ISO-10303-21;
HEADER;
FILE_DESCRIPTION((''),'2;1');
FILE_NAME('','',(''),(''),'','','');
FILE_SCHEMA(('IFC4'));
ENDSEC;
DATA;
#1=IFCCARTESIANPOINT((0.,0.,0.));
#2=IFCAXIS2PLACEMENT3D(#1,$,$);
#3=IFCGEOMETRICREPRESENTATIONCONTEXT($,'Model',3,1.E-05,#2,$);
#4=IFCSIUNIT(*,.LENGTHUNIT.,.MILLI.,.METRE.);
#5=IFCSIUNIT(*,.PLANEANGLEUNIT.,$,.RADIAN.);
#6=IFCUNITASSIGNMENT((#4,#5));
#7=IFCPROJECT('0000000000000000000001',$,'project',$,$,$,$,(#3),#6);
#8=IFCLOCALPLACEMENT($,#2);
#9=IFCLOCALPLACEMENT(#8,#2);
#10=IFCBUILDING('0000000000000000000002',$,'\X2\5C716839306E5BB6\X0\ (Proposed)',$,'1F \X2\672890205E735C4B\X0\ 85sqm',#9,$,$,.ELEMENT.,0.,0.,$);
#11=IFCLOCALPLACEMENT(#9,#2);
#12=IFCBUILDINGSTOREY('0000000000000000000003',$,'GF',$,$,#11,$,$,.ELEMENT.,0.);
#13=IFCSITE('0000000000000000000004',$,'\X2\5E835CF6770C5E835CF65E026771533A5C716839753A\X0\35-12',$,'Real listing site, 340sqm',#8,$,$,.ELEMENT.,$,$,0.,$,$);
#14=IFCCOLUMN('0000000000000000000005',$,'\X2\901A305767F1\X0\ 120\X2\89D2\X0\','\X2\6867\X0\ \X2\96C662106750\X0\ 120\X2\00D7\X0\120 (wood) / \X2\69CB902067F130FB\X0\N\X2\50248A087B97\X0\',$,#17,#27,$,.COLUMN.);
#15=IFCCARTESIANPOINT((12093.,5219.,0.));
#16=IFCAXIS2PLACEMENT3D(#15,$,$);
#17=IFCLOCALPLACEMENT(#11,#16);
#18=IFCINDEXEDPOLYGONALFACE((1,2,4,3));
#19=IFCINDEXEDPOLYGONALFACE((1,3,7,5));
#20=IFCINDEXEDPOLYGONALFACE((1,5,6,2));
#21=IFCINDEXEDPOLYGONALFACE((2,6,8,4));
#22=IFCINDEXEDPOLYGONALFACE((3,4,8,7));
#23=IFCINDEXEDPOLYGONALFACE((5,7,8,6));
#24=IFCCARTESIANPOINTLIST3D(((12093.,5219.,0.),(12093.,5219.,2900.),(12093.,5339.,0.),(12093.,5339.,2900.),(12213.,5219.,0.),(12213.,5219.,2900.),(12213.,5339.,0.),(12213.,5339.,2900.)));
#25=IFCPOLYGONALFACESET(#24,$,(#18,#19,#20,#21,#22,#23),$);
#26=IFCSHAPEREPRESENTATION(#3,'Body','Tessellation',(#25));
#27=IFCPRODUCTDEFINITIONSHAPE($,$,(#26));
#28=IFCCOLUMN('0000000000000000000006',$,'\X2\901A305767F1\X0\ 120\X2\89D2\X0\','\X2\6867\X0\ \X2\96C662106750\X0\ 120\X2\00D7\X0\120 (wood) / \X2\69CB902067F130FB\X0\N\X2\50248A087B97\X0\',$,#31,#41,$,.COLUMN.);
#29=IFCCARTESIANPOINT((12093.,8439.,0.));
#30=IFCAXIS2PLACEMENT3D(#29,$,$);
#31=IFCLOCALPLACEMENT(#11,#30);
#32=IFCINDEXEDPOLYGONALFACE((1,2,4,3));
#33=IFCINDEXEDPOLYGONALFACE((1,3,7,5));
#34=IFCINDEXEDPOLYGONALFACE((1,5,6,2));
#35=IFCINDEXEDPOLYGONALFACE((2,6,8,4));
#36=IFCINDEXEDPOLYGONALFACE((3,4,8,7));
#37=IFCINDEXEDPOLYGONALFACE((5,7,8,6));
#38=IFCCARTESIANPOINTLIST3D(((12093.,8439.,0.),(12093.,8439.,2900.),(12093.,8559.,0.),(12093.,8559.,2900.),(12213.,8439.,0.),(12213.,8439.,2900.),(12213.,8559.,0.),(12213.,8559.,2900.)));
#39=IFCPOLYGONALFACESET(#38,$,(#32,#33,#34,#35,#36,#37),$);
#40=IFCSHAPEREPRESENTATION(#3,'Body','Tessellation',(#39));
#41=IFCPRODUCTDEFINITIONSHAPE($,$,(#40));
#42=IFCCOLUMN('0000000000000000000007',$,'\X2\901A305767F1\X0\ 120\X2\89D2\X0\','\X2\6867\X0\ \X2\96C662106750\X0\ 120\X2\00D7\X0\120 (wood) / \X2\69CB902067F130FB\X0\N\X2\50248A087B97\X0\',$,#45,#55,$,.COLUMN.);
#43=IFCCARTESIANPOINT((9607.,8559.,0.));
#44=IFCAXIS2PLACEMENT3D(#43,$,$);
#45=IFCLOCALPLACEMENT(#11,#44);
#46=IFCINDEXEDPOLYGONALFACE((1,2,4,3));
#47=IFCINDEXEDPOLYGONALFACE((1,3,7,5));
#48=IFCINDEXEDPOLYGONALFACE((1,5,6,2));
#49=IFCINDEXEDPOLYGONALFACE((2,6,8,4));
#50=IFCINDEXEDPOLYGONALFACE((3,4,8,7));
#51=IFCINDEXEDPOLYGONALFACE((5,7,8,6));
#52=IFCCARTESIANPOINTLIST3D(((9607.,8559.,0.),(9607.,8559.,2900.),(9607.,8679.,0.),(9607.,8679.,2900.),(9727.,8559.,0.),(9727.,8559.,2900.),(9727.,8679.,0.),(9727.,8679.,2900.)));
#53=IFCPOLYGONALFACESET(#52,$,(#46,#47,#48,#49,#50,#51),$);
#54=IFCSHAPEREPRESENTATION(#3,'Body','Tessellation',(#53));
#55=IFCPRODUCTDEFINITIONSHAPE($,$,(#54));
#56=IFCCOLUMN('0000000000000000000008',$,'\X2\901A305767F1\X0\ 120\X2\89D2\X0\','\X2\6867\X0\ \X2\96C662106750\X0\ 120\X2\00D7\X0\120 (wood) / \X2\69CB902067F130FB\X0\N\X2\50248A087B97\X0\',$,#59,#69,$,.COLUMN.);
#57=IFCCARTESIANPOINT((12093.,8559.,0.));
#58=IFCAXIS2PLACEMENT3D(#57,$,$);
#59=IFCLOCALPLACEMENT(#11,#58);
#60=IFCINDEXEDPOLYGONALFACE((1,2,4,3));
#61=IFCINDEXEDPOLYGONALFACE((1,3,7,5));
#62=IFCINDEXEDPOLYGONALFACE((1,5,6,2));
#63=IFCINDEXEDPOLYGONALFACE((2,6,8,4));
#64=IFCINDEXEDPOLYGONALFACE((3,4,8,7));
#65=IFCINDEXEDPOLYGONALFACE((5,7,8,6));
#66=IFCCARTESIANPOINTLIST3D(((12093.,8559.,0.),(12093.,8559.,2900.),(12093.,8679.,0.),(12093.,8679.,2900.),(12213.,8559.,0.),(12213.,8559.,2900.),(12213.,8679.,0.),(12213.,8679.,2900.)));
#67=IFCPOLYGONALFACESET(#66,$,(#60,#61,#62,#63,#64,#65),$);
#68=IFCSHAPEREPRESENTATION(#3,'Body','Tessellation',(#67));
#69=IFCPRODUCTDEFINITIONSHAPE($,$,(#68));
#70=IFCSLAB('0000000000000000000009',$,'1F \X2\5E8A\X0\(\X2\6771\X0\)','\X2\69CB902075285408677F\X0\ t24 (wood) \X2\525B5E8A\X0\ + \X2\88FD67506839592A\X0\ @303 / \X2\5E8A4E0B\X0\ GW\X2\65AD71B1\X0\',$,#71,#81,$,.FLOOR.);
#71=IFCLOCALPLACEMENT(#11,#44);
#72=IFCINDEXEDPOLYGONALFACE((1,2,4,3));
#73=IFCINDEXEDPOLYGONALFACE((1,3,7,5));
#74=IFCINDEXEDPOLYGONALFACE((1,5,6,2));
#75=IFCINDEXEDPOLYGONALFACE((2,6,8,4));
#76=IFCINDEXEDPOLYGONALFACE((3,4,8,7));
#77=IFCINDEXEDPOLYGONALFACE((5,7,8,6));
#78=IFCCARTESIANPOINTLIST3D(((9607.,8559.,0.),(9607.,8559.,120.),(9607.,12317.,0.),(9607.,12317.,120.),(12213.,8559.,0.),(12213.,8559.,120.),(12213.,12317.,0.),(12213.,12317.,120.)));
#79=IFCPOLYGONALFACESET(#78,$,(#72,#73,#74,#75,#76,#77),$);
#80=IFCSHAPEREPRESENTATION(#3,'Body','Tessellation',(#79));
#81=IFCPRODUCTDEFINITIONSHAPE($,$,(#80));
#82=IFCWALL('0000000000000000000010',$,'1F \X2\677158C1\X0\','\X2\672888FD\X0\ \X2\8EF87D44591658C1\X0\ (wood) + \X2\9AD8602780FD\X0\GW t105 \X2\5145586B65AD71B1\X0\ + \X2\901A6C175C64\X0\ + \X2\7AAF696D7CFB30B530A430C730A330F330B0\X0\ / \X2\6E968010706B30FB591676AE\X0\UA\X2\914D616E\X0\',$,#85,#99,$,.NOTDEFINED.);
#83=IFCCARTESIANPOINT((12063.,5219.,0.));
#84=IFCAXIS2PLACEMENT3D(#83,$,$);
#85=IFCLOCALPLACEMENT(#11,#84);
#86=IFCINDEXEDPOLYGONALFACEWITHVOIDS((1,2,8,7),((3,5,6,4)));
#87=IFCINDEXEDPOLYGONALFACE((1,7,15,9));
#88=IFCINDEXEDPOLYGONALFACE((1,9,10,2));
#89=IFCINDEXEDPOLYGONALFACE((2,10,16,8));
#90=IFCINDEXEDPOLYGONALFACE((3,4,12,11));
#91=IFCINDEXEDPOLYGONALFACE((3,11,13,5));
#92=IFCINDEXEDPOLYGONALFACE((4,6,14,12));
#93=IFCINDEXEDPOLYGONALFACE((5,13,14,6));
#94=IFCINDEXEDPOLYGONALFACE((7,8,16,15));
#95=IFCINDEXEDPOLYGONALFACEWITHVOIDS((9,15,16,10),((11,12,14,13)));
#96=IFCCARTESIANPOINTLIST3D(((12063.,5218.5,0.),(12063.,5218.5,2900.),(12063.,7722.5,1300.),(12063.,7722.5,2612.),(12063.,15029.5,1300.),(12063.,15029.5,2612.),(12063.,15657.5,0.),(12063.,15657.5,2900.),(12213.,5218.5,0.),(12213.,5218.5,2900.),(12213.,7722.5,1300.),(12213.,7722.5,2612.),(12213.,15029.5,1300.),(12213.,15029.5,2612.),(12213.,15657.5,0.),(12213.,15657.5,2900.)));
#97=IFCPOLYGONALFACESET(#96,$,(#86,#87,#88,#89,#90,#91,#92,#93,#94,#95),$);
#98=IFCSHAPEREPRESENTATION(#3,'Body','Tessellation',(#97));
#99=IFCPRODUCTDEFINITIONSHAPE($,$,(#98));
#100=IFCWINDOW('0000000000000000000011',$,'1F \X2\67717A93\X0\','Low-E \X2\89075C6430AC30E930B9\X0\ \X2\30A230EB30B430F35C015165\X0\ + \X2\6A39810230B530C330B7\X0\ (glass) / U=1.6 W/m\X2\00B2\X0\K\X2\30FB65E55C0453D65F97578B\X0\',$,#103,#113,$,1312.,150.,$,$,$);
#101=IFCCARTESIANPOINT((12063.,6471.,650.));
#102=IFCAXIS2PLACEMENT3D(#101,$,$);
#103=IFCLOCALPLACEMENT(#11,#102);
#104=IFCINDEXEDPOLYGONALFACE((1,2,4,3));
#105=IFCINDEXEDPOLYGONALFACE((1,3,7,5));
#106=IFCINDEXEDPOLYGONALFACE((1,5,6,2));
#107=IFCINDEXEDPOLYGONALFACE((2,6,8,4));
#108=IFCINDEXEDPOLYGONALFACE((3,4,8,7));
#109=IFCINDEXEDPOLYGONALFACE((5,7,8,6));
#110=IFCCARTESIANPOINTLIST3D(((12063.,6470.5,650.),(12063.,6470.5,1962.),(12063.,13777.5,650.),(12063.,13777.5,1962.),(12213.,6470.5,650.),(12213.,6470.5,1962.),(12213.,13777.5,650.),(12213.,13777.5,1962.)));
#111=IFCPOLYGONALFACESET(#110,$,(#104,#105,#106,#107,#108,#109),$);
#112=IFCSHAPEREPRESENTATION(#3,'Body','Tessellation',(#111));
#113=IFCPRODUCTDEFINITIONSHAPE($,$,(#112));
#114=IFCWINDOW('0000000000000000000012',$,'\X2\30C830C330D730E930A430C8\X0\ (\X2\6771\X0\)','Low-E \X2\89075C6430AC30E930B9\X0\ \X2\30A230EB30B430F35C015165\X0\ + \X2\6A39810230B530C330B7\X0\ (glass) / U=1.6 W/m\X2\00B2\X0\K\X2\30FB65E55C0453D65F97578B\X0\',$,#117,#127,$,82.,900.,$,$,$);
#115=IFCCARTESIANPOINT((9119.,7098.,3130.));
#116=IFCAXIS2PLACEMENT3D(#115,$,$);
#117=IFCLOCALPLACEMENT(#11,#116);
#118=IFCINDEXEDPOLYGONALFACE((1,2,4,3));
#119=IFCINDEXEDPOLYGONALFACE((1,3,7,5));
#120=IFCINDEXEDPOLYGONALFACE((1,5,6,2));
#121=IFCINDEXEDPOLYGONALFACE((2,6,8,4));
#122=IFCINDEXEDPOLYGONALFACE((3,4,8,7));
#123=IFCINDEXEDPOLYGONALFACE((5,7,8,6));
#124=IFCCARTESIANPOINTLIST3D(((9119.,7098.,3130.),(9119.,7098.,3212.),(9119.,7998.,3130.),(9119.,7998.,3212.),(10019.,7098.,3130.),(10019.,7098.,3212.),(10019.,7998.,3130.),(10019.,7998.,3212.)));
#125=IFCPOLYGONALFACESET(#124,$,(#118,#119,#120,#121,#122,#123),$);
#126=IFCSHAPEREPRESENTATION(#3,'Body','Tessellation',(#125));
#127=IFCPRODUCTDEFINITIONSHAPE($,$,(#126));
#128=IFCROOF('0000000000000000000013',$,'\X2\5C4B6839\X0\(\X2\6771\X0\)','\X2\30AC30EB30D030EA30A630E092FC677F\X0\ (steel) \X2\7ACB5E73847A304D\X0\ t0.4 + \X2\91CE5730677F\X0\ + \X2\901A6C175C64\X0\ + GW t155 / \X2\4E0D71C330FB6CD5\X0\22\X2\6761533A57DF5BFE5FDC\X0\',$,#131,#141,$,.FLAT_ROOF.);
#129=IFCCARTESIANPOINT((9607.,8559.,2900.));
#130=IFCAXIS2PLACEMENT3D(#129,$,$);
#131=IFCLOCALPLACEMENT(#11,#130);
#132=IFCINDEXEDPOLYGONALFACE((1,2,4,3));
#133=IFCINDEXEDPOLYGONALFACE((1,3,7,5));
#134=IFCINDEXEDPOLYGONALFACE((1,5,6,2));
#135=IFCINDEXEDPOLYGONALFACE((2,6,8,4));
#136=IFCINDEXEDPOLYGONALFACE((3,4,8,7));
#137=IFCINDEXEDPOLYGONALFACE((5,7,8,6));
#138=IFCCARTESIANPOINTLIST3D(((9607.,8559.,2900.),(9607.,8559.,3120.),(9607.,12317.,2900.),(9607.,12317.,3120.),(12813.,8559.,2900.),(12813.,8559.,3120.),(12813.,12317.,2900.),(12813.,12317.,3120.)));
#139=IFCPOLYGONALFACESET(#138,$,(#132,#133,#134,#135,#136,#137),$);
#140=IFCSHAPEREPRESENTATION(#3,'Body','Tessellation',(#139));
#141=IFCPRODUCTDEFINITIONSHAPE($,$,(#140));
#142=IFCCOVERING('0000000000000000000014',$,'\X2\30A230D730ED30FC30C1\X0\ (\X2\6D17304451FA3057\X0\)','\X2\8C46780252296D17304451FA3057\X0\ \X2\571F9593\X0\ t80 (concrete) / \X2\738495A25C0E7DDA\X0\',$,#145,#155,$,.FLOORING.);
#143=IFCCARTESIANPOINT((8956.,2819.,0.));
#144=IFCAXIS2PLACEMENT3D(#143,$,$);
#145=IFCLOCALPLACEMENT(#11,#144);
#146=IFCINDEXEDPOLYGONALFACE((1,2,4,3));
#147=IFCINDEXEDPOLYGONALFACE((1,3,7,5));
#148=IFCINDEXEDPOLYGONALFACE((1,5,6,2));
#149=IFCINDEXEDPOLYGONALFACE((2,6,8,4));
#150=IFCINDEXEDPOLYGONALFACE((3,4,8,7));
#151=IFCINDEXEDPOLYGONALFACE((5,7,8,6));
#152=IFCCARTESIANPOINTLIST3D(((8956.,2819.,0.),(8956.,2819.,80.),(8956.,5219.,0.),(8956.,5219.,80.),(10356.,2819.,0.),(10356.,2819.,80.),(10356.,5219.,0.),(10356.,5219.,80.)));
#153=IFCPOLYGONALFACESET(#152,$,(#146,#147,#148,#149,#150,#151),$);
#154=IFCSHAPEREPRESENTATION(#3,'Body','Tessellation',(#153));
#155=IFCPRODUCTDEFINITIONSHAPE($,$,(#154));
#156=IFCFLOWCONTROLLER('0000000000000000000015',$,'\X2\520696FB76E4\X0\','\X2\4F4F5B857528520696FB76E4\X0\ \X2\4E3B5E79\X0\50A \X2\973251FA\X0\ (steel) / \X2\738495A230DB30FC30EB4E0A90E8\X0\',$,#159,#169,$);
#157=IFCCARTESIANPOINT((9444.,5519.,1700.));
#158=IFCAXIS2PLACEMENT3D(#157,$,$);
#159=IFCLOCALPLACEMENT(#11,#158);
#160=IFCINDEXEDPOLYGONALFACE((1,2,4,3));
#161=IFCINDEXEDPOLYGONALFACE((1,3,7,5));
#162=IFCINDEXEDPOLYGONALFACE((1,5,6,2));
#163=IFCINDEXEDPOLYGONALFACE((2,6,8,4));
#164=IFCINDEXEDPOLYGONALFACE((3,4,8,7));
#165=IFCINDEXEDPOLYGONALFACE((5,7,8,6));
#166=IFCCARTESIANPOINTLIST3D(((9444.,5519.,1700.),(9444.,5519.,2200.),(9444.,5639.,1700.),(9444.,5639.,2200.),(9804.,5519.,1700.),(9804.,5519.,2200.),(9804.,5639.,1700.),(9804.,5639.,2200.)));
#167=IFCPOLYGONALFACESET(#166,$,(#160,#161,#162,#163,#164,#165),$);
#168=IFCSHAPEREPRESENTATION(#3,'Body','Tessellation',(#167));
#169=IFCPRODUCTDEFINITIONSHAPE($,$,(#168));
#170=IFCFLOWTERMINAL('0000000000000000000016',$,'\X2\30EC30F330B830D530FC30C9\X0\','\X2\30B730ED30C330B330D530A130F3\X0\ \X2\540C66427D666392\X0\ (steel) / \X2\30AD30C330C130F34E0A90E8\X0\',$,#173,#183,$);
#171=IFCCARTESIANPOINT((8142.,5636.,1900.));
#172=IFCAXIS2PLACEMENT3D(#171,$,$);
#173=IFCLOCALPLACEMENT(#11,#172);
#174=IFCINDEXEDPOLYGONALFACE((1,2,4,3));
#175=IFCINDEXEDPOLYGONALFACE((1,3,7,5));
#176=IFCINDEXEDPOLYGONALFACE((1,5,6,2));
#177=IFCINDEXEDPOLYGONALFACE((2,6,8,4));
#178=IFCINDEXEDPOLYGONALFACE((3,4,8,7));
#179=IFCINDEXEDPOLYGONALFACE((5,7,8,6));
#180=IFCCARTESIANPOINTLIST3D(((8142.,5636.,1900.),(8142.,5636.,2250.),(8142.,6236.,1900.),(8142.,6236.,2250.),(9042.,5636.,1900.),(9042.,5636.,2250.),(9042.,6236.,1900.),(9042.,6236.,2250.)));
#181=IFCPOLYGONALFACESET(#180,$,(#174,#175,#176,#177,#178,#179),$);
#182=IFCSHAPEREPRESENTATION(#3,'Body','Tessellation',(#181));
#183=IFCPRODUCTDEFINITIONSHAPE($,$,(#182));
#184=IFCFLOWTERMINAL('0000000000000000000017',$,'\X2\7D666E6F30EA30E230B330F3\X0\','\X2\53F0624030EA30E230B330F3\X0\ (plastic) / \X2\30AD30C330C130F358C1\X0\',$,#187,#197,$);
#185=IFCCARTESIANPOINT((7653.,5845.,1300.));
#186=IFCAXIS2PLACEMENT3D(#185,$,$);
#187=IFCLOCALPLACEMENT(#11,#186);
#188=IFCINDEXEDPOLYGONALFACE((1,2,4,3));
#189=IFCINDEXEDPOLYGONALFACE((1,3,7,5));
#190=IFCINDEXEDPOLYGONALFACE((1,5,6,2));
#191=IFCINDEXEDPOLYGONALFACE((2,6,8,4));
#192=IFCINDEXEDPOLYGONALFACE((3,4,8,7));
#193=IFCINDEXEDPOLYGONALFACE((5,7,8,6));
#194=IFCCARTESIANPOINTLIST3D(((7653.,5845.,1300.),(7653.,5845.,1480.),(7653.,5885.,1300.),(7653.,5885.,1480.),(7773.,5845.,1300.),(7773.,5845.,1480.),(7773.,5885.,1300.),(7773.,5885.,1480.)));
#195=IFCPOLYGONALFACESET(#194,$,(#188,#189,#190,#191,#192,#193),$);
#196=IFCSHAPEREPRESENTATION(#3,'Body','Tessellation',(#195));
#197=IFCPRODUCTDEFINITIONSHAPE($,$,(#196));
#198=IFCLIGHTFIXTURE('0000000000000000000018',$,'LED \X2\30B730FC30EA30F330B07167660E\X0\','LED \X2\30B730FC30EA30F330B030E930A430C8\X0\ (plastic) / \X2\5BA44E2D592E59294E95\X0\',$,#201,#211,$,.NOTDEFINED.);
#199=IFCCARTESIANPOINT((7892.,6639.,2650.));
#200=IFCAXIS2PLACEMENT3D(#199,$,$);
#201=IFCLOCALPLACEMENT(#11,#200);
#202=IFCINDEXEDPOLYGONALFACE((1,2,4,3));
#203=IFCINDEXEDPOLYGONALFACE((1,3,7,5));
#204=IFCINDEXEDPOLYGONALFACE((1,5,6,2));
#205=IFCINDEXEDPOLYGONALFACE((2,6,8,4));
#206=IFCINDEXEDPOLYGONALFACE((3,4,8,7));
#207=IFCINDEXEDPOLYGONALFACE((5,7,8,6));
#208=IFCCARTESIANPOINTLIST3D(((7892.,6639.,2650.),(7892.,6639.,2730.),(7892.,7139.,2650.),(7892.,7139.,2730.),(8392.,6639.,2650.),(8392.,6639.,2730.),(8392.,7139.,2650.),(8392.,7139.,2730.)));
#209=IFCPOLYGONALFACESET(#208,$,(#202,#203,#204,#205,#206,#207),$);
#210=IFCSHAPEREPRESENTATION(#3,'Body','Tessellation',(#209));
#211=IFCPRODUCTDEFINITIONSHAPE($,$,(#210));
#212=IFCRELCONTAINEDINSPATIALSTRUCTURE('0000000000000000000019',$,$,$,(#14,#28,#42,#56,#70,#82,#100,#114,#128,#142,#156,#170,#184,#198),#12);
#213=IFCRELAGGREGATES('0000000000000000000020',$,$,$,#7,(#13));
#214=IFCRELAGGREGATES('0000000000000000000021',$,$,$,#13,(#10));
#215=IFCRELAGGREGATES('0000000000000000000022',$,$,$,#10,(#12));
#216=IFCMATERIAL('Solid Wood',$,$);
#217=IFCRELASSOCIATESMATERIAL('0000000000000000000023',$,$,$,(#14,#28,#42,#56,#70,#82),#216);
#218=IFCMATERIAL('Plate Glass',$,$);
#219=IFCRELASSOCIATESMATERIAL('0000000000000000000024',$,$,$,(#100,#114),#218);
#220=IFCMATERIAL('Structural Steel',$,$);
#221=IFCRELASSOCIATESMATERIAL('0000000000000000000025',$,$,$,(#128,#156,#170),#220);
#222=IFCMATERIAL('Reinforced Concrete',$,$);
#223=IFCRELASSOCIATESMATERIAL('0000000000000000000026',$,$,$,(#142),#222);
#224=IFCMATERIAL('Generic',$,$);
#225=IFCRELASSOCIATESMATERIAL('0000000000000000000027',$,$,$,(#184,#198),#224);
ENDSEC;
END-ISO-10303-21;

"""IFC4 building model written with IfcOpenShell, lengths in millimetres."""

from ifc_helpers import new_model, si_unit, frame, frame_2d, origin, place, context, project, spatial, rectangle, extrude, material, element, fill, save


model = new_model("IFC4")

# Units and contexts
model_context = context("Model", 3, precision=1e-05, world=origin())
ifc_project = project(units=[si_unit("LENGTHUNIT", "METRE", prefix="MILLI"), si_unit("PLANEANGLEUNIT", "RADIAN")], contexts=[model_context])

# Site, building, storey
site_placement = place(None, origin())
site = spatial("IfcSite", under=ifc_project, at=site_placement, Name="広島県広島市東区山根町35-12", ObjectType="Real listing site, 340sqm", CompositionType="ELEMENT", RefElevation=0.0)
building_placement = place(site_placement, origin())
building = spatial("IfcBuilding", under=site, at=building_placement, Name="山根の家 (Proposed)", ObjectType="1F 木造平屋 85sqm", CompositionType="ELEMENT", ElevationOfRefHeight=0.0, ElevationOfTerrain=0.0)
storey_placement = place(building_placement, origin())
storey = spatial("IfcBuildingStorey", under=building, at=storey_placement, Name="GF", CompositionType="ELEMENT", Elevation=0.0)

# Columns
ifc_material_1 = material(Name="Solid Wood")
column_1_placement = place(storey_placement, frame((12093.0, 5219.0, 0.0)))
element("IfcColumn", 1, at=column_1_placement, inside=storey, material=ifc_material_1, Name="通し柱 120角", Description="桧 集成材 120×120 (wood) / 構造柱・N値計算", PredefinedType="COLUMN", context=model_context, shape_type="SweptSolid", body=[
    extrude(rectangle(XDim=120.0, YDim=120.0, at=frame_2d((60.0, 60.0))), frame((12093.0, 5219.0, 0.0)), (0.0, 0.0, 1.0), 2900.0),
])
column_2_placement = place(storey_placement, frame((12093.0, 8439.0, 0.0)))
element("IfcColumn", 2, at=column_2_placement, inside=storey, material=ifc_material_1, Name="通し柱 120角", Description="桧 集成材 120×120 (wood) / 構造柱・N値計算", PredefinedType="COLUMN", context=model_context, shape_type="SweptSolid", body=[
    extrude(rectangle(XDim=120.0, YDim=120.0, at=frame_2d((60.0, 60.0))), frame((12093.0, 8439.0, 0.0)), (0.0, 0.0, 1.0), 2900.0),
])
column_3_placement = place(storey_placement, frame((9607.0, 8559.0, 0.0)))
element("IfcColumn", 3, at=column_3_placement, inside=storey, material=ifc_material_1, Name="通し柱 120角", Description="桧 集成材 120×120 (wood) / 構造柱・N値計算", PredefinedType="COLUMN", context=model_context, shape_type="SweptSolid", body=[
    extrude(rectangle(XDim=120.0, YDim=120.0, at=frame_2d((60.0, 60.0))), frame((9607.0, 8559.0, 0.0)), (0.0, 0.0, 1.0), 2900.0),
])
column_4_placement = place(storey_placement, frame((12093.0, 8559.0, 0.0)))
element("IfcColumn", 4, at=column_4_placement, inside=storey, material=ifc_material_1, Name="通し柱 120角", Description="桧 集成材 120×120 (wood) / 構造柱・N値計算", PredefinedType="COLUMN", context=model_context, shape_type="SweptSolid", body=[
    extrude(rectangle(XDim=120.0, YDim=120.0, at=frame_2d((60.0, 60.0))), frame((12093.0, 8559.0, 0.0)), (0.0, 0.0, 1.0), 2900.0),
])

# Slab
slab_placement = place(storey_placement, frame((9607.0, 8559.0, 0.0)))
element("IfcSlab", 5, at=slab_placement, inside=storey, material=ifc_material_1, Name="1F 床(東)", Description="構造用合板 t24 (wood) 剛床 + 製材根太 @303 / 床下 GW断熱", PredefinedType="FLOOR", context=model_context, shape_type="SweptSolid", body=[
    extrude(rectangle(XDim=2606.0, YDim=3758.0, at=frame_2d((1303.0, 1879.0))), frame((9607.0, 8559.0, 0.0)), (0.0, 0.0, 1.0), 120.0),
])

# Wall, opening, window
wall_1_placement = place(storey_placement, frame((12063.0, 5219.0, 0.0)))
wall_1 = element("IfcWall", 6, at=wall_1_placement, inside=storey, material=ifc_material_1, Name="1F 東壁", Description="木製 軸組外壁 (wood) + 高性能GW t105 充填断熱 + 通気層 + 窯業系サイディング / 準耐火・外皮UA配慮", PredefinedType="NOTDEFINED", context=model_context, shape_type="SweptSolid", body=[
    extrude(rectangle(XDim=150.0, YDim=10439.0, at=frame_2d((75.0, 5219.0))), frame((12063.0, 5219.0, 0.0)), (0.0, 0.0, 1.0), 2900.0),
])
opening_placement = place(storey_placement, frame((12063.0, 6471.0, 650.0)))
opening = element("IfcOpeningElement", 7, at=opening_placement, cuts=wall_1, PredefinedType="NOTDEFINED", context=model_context, shape_type="SweptSolid", body=[
    extrude(rectangle(XDim=150.0, YDim=7307.0, at=frame_2d((75.0, 3653.0))), frame((12063.0, 6471.0, 650.0)), (0.0, 0.0, 1.0), 1312.0),
])
ifc_material_2 = material(Name="Plate Glass")
window_1_placement = place(storey_placement, frame((12063.0, 6471.0, 650.0)))
window_1 = element("IfcWindow", 8, at=window_1_placement, inside=storey, material=ifc_material_2, Name="1F 東窓", Description="Low-E 複層ガラス アルゴン封入 + 樹脂サッシ (glass) / U=1.6 W/m²K・日射取得型", OverallHeight=1312.0, OverallWidth=150.0, context=model_context, shape_type="SweptSolid", body=[
    extrude(rectangle(XDim=150.0, YDim=7307.0, at=frame_2d((75.0, 3653.0))), frame((12063.0, 6471.0, 650.0)), (0.0, 0.0, 1.0), 1312.0),
])
fill(opening, window_1)

# Window
window_2_placement = place(storey_placement, frame((9119.0, 7098.0, 3130.0)))
element("IfcWindow", 9, at=window_2_placement, inside=storey, material=ifc_material_2, Name="トップライト (東)", Description="Low-E 複層ガラス アルゴン封入 + 樹脂サッシ (glass) / U=1.6 W/m²K・日射取得型", OverallHeight=82.0, OverallWidth=900.0, context=model_context, shape_type="SweptSolid", body=[
    extrude(rectangle(XDim=900.0, YDim=900.0, at=frame_2d((450.0, 450.0))), frame((9119.0, 7098.0, 3130.0)), (0.0, 0.0, 1.0), 82.0),
])

# Roof
ifc_material_3 = material(Name="Structural Steel")
roof_placement = place(storey_placement, frame((9607.0, 8559.0, 2900.0)))
element("IfcRoof", 10, at=roof_placement, inside=storey, material=ifc_material_3, Name="屋根(東)", Description="ガルバリウム鋼板 (steel) 立平葺き t0.4 + 野地板 + 通気層 + GW t155 / 不燃・法22条区域対応", PredefinedType="FLAT_ROOF", context=model_context, shape_type="SweptSolid", body=[
    extrude(rectangle(XDim=3206.0, YDim=3758.0, at=frame_2d((1603.0, 1879.0))), frame((9607.0, 8559.0, 2900.0)), (0.0, 0.0, 1.0), 220.0),
])

# Covering
ifc_material_4 = material(Name="Reinforced Concrete")
covering_placement = place(storey_placement, frame((8956.0, 2819.0, 0.0)))
element("IfcCovering", 11, at=covering_placement, inside=storey, material=ifc_material_4, Name="アプローチ (洗い出し)", Description="豆砂利洗い出し 土間 t80 (concrete) / 玄関導線", PredefinedType="FLOORING", context=model_context, shape_type="SweptSolid", body=[
    extrude(rectangle(XDim=1400.0, YDim=2400.0, at=frame_2d((700.0, 1200.0))), frame((8956.0, 2819.0, 0.0)), (0.0, 0.0, 1.0), 80.0),
])

# Flow controller
flow_controller_placement = place(storey_placement, frame((9444.0, 5519.0, 1700.0)))
element("IfcFlowController", 12, at=flow_controller_placement, inside=storey, material=ifc_material_3, Name="分電盤", Description="住宅用分電盤 主幹50A 露出 (steel) / 玄関ホール上部", context=model_context, shape_type="SweptSolid", body=[
    extrude(rectangle(XDim=360.0, YDim=120.0, at=frame_2d((180.0, 60.0))), frame((9444.0, 5519.0, 1700.0)), (0.0, 0.0, 1.0), 500.0),
])

# Flow terminals
flow_terminal_1_placement = place(storey_placement, frame((8142.0, 5636.0, 1900.0)))
element("IfcFlowTerminal", 13, at=flow_terminal_1_placement, inside=storey, material=ifc_material_3, Name="レンジフード", Description="シロッコファン 同時給排 (steel) / キッチン上部", context=model_context, shape_type="SweptSolid", body=[
    extrude(rectangle(XDim=900.0, YDim=600.0, at=frame_2d((450.0, 300.0))), frame((8142.0, 5636.0, 1900.0)), (0.0, 0.0, 1.0), 350.0),
])
ifc_material_5 = material(Name="Generic")
flow_terminal_2_placement = place(storey_placement, frame((7653.0, 5845.0, 1300.0)))
element("IfcFlowTerminal", 14, at=flow_terminal_2_placement, inside=storey, material=ifc_material_5, Name="給湯リモコン", Description="台所リモコン (plastic) / キッチン壁", context=model_context, shape_type="SweptSolid", body=[
    extrude(rectangle(XDim=120.0, YDim=40.0, at=frame_2d((60.0, 20.0))), frame((7653.0, 5845.0, 1300.0)), (0.0, 0.0, 1.0), 180.0),
])

# Light fixture
light_fixture_placement = place(storey_placement, frame((7892.0, 6639.0, 2650.0)))
element("IfcLightFixture", 15, at=light_fixture_placement, inside=storey, material=ifc_material_5, Name="LED シーリング照明", Description="LED シーリングライト (plastic) / 室中央天井", PredefinedType="NOTDEFINED", context=model_context, shape_type="SweptSolid", body=[
    extrude(rectangle(XDim=500.0, YDim=500.0, at=frame_2d((250.0, 250.0))), frame((7892.0, 6639.0, 2650.0)), (0.0, 0.0, 1.0), 80.0),
])

save(model, "model.ifc")
